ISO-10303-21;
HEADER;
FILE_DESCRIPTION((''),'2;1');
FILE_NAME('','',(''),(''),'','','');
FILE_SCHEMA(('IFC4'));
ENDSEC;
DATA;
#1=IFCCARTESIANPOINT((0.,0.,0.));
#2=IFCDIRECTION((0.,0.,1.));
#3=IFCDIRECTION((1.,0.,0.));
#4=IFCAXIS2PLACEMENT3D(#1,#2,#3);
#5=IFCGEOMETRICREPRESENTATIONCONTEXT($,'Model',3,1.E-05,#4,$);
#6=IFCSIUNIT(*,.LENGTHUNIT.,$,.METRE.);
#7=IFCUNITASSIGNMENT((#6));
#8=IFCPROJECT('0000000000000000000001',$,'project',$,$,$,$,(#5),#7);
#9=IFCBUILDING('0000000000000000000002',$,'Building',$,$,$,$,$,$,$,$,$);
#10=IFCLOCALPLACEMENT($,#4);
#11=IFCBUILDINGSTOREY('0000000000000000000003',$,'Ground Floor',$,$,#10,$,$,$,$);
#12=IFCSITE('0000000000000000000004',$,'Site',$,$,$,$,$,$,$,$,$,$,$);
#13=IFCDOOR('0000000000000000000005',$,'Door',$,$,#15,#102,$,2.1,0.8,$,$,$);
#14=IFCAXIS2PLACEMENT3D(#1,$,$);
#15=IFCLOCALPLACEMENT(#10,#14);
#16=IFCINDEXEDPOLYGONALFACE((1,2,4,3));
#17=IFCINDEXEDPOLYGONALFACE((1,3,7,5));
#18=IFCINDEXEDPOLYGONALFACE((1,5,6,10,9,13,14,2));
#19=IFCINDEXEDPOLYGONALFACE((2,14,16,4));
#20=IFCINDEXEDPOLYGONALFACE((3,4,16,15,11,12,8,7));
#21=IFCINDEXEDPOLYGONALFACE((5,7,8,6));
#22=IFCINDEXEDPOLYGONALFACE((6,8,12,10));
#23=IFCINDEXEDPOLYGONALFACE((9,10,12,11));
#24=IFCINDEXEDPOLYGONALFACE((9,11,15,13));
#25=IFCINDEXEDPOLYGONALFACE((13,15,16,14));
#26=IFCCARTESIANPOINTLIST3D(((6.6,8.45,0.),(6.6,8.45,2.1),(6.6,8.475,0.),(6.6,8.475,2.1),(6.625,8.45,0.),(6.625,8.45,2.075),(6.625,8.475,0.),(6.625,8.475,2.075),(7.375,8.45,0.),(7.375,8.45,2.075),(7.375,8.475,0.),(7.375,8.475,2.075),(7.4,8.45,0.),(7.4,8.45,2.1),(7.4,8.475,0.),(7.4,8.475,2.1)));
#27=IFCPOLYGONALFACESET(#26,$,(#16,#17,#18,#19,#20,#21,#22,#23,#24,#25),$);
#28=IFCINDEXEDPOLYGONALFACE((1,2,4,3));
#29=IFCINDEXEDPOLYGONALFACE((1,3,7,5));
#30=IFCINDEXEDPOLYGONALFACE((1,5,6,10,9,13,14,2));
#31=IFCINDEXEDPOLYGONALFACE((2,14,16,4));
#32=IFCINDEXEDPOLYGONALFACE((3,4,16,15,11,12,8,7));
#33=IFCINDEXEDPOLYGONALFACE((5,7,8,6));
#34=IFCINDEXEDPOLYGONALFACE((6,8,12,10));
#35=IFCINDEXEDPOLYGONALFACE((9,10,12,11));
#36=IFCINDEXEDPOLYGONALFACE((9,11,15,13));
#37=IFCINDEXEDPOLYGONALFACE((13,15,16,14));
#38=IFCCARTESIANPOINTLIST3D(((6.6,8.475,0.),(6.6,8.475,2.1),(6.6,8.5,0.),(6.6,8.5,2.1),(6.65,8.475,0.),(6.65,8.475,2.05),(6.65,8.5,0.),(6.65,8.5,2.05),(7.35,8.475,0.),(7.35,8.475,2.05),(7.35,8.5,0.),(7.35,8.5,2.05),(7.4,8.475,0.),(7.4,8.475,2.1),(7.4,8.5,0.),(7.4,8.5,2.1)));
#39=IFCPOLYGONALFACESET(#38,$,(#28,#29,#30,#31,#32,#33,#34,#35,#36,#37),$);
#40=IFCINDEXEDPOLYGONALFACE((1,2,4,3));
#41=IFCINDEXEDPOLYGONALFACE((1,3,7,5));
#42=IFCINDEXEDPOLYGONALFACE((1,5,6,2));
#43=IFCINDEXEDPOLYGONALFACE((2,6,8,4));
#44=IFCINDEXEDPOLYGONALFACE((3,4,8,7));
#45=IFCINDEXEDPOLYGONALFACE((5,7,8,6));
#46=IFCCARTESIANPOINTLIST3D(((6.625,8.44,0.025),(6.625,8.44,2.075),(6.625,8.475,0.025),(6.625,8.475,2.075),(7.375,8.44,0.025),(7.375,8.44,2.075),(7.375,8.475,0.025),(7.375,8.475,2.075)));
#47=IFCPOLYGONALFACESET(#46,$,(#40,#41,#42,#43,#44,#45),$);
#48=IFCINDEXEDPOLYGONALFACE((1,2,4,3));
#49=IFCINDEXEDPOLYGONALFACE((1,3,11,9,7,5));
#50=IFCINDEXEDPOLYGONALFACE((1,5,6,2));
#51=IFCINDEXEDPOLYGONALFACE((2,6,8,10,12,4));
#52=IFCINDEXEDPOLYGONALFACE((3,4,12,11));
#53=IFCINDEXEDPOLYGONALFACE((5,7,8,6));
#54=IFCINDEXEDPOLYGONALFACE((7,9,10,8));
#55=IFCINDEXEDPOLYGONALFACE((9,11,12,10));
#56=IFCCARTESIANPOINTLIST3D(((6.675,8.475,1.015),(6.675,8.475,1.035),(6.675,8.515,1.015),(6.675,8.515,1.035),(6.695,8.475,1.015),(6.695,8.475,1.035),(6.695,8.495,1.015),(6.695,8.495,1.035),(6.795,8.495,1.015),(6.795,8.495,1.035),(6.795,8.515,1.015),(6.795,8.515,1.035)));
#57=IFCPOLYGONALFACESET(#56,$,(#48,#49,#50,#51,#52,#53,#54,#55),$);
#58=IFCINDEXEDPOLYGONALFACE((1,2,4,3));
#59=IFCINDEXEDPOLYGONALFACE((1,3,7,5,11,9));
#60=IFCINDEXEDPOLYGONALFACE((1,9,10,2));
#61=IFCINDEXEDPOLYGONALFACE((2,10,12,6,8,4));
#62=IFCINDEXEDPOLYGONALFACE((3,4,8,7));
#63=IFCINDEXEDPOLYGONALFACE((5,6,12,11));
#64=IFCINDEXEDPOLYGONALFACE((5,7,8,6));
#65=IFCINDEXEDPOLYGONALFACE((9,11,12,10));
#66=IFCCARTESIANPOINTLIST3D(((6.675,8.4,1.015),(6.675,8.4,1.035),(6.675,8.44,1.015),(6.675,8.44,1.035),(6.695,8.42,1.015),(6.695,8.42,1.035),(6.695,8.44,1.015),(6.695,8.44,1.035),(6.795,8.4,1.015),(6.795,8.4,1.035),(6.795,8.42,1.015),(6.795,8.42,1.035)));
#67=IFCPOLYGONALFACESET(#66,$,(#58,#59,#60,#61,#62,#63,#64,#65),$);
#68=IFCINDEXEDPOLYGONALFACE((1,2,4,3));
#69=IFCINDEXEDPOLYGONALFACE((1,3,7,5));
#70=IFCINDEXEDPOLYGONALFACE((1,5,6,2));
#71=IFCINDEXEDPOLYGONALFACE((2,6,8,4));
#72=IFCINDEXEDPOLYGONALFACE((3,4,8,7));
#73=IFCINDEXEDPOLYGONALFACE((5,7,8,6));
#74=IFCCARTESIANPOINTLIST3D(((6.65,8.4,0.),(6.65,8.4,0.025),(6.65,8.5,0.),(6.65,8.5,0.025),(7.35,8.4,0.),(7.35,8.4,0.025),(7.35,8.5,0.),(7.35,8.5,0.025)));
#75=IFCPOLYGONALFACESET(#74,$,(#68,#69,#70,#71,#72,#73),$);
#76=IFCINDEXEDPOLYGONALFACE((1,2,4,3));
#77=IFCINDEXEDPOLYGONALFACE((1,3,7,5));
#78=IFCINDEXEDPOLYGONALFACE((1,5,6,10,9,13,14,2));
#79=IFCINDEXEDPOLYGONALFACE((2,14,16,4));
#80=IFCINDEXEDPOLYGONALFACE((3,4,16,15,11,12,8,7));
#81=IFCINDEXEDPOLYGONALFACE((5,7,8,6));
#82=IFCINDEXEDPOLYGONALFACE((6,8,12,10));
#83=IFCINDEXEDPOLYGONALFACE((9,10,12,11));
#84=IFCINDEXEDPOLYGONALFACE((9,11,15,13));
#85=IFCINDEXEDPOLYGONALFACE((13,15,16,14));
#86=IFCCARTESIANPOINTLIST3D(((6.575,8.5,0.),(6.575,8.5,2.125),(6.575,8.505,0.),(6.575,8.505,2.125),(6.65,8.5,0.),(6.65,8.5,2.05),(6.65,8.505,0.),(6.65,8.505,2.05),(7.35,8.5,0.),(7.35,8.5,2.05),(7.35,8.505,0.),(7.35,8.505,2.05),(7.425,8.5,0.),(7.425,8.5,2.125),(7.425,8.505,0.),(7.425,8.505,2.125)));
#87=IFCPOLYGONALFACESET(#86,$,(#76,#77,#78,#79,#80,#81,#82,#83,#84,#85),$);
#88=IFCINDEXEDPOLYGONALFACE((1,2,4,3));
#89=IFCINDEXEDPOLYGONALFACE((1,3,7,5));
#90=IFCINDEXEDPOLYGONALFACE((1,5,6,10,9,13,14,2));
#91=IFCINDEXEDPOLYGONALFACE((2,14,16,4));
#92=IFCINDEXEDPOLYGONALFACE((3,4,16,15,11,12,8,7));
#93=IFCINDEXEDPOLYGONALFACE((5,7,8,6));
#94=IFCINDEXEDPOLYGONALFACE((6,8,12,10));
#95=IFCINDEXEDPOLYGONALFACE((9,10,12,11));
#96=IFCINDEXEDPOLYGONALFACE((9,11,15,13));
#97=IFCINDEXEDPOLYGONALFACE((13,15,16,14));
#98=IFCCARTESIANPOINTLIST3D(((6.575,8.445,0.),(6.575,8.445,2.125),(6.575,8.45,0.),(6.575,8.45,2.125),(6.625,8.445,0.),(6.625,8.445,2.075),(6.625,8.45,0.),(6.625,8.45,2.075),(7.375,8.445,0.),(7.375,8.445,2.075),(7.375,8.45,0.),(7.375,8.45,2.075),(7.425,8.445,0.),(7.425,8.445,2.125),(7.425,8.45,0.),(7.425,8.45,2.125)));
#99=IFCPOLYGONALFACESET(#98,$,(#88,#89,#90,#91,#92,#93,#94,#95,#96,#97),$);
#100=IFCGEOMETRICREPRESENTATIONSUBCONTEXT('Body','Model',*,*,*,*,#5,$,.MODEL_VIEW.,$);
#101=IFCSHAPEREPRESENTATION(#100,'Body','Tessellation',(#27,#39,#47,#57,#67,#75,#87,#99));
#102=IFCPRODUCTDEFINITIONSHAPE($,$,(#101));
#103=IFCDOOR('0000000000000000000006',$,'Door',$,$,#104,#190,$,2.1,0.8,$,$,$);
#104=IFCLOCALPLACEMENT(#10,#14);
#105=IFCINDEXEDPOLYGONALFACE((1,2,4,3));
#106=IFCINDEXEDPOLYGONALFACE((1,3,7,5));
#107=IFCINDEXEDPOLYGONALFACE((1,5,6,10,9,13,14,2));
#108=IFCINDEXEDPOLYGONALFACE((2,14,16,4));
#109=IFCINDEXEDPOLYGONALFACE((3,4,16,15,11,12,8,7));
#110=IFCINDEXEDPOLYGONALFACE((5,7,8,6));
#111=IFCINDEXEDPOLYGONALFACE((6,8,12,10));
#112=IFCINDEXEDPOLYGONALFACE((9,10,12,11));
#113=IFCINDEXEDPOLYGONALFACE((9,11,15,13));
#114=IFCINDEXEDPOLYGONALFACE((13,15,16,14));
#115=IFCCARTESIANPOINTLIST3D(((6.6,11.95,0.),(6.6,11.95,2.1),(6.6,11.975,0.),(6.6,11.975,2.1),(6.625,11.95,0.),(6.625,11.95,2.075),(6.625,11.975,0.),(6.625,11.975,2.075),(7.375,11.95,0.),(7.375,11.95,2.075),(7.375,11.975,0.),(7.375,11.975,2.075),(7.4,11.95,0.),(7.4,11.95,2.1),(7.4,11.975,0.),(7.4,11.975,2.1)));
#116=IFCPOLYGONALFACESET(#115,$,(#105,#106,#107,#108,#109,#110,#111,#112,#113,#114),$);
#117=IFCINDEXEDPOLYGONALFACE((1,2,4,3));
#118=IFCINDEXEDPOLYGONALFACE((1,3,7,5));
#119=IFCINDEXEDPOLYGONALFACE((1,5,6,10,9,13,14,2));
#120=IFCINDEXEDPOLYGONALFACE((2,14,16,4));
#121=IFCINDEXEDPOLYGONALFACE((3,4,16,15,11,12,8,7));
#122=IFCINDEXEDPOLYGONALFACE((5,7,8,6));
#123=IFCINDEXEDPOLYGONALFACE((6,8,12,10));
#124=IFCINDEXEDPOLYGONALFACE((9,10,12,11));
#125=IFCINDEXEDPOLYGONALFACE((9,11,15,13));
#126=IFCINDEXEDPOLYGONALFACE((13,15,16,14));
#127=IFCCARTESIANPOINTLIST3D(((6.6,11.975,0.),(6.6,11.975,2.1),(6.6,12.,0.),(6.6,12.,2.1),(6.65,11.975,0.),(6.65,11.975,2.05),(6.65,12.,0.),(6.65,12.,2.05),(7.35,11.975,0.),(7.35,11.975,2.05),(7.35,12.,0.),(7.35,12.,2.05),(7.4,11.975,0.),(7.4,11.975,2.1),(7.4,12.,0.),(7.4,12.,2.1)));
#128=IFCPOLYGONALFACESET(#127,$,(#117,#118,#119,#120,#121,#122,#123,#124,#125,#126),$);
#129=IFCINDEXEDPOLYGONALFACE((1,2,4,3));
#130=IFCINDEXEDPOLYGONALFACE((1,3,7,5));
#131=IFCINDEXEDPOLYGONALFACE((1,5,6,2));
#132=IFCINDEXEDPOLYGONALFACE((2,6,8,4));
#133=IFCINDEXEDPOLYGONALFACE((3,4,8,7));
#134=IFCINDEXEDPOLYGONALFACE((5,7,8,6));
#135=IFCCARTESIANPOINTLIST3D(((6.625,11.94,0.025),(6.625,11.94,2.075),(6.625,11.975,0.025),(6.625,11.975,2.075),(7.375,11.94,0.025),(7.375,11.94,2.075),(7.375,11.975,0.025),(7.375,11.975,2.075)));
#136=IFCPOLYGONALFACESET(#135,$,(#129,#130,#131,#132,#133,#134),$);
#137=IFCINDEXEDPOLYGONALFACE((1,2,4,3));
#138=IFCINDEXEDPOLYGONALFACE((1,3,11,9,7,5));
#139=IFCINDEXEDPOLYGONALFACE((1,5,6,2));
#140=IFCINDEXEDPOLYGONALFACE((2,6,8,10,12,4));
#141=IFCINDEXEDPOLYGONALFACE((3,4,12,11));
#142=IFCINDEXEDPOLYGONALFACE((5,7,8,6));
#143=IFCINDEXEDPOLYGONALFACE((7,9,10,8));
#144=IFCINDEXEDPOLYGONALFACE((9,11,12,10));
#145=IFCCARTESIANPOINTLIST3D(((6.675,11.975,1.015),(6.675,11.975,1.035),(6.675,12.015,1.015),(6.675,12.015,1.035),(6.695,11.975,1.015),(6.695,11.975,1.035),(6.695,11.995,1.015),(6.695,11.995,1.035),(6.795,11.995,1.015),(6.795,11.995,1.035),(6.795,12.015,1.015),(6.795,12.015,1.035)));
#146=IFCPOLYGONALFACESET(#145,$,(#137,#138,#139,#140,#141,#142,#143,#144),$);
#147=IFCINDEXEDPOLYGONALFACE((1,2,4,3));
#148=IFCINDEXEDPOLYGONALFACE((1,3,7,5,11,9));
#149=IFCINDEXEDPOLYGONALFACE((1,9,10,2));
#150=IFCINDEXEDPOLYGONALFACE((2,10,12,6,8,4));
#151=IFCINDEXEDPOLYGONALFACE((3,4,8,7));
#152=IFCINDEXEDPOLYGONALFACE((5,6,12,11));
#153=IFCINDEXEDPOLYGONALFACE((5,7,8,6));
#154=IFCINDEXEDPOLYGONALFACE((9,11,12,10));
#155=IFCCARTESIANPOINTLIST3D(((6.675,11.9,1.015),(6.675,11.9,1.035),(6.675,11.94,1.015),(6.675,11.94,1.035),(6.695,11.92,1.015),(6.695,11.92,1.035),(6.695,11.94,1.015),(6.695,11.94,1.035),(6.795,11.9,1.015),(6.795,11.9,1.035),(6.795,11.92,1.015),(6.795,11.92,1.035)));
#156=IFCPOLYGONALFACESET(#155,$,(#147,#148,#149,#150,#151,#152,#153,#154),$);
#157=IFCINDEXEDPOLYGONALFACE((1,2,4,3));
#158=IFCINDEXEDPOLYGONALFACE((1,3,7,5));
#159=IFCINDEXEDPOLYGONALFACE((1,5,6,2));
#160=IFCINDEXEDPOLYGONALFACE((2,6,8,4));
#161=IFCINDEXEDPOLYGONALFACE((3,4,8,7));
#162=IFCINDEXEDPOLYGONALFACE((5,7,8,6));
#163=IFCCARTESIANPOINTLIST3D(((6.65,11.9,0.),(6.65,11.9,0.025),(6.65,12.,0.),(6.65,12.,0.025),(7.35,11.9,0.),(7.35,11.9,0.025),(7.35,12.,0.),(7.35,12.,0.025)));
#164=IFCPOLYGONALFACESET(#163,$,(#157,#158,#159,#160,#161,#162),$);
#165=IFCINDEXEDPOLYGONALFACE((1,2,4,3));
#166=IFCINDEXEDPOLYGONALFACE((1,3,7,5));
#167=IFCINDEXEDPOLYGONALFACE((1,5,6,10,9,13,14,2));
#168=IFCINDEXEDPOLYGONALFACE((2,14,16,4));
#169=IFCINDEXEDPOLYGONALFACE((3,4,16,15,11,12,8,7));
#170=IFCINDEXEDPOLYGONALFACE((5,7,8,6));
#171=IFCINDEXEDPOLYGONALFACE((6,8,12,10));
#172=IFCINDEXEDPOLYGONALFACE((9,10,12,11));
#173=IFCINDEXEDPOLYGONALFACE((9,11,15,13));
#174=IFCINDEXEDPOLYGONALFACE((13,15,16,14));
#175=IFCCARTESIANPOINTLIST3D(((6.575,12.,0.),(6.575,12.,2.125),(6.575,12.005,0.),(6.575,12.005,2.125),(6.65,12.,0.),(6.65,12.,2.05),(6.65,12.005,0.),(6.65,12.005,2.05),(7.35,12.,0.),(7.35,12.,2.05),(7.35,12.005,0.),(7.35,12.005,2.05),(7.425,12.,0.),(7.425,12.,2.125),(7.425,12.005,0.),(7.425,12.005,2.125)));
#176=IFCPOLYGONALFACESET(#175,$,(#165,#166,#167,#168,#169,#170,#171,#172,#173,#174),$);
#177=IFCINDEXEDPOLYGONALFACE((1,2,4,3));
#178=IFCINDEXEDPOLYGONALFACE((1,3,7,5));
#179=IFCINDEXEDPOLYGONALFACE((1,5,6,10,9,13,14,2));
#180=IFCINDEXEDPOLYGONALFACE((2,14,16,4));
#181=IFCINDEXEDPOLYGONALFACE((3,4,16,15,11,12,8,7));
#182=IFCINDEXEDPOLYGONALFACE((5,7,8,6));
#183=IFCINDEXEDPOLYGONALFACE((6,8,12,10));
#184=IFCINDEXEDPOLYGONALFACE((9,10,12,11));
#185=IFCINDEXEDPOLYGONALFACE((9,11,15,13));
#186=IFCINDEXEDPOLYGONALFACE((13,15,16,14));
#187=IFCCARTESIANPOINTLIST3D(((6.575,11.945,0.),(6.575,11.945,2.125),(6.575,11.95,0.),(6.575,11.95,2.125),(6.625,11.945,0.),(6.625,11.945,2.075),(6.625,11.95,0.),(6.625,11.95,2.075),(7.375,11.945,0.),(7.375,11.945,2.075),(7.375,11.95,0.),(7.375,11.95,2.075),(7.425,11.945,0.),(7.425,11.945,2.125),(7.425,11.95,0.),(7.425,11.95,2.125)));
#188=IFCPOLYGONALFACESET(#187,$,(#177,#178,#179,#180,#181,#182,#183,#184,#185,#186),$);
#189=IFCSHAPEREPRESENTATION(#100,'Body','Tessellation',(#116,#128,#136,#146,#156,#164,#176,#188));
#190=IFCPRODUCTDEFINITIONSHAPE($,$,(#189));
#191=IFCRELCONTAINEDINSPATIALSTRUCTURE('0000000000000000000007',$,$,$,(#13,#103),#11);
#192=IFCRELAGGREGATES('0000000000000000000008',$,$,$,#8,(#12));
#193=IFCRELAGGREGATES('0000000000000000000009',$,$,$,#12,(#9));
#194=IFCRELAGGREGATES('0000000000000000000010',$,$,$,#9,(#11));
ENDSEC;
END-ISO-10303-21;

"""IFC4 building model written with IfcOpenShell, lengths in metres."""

from ifc_helpers import new_model, si_unit, frame, origin_with_axes, place, context, subcontext, project, spatial, line, indexed_curve, outline, extrude, element, save


model = new_model("IFC4")

# Units and contexts
model_context = context("Model", 3, precision=1e-05, world=origin_with_axes())
body_context = subcontext(model_context, "Body", "Model", "MODEL_VIEW")
ifc_project = project(units=[si_unit("LENGTHUNIT", "METRE")], contexts=[model_context])

# Site, building, storey
site = spatial("IfcSite", under=ifc_project, Name="Site")
building = spatial("IfcBuilding", under=site, Name="Building")
storey_placement = place(None, origin_with_axes())
storey = spatial("IfcBuildingStorey", under=building, at=storey_placement, Name="Ground Floor")

# Doors
door_1_placement = place(storey_placement, frame((7.4, 8.5, 0.0), z_axis=(0.0, 0.0, 1.0), x_axis=(-1.0, 0.0, 0.0)))
element("IfcDoor", 1, at=door_1_placement, inside=storey, Name="Door", OverallHeight=2.1, OverallWidth=0.8, context=body_context, shape_type="SweptSolid", body=[
    extrude(outline(indexed_curve([(0.0, 0.0), (0.0, 2.1), (0.8, 2.1), (0.8, 0.0), (0.775, 0.0), (0.775, 2.075), (0.025, 2.075), (0.025, 0.0)], segments=[line(1, 2, 3, 4, 5, 6, 7, 8, 1)])), frame((0.0, 0.025, 0.0), z_axis=(0.0, -1.0, 0.0), x_axis=(1.0, 0.0, 0.0)), (0.0, 0.0, -1.0), 0.025),
    extrude(outline(indexed_curve([(0.0, 0.0), (0.0, 2.1), (0.8, 2.1), (0.8, 0.0), (0.75, 0.0), (0.75, 2.05), (0.05, 2.05), (0.05, 0.0)], segments=[line(1, 2, 3, 4, 5, 6, 7, 8, 1)])), frame((0.0, 0.0, 0.0), z_axis=(0.0, -1.0, 0.0), x_axis=(1.0, 0.0, 0.0)), (0.0, 0.0, -1.0), 0.025),
    extrude(outline(indexed_curve([(0.0, 0.0), (0.75, 0.0), (0.75, 0.035), (0.0, 0.035)], segments=[line(1, 2, 3, 4, 1)])), frame((0.025, 0.025, 0.025), z_axis=(0.0, 0.0, 1.0), x_axis=(1.0, 0.0, 0.0)), (0.0, 0.0, 1.0), 2.05),
    extrude(outline(indexed_curve([(0.0, 0.0), (0.0, -0.04), (-0.12, -0.04), (-0.12, -0.02), (-0.02, -0.02), (-0.02, 0.0)], segments=[line(1, 2, 3, 4, 5, 6, 1)])), frame((0.725, 0.025, 1.015), z_axis=(0.0, 0.0, 1.0), x_axis=(1.0, 0.0, 0.0)), (0.0, 0.0, 1.0), 0.02),
    extrude(outline(indexed_curve([(0.0, 0.0), (0.0, 0.04), (-0.12, 0.04), (-0.12, 0.02), (-0.02, 0.02), (-0.02, 0.0)], segments=[line(1, 2, 3, 4, 5, 6, 1)])), frame((0.725, 0.06, 1.015), z_axis=(0.0, 0.0, 1.0), x_axis=(1.0, 0.0, 0.0)), (0.0, 0.0, 1.0), 0.02),
    extrude(outline(indexed_curve([(0.0, 0.0), (0.7, 0.0), (0.7, 0.1), (0.0, 0.1)], segments=[line(1, 2, 3, 4, 1)])), frame((0.05, 0.0, 0.0), z_axis=(0.0, 0.0, 1.0), x_axis=(1.0, 0.0, 0.0)), (0.0, 0.0, 1.0), 0.025),
    extrude(outline(indexed_curve([(0.0, 0.0), (0.0, 2.125), (0.85, 2.125), (0.85, 0.0), (0.775, 0.0), (0.775, 2.05), (0.075, 2.05), (0.075, 0.0)], segments=[line(1, 2, 3, 4, 5, 6, 7, 8, 1)])), frame((-0.025, -0.005, 0.0), z_axis=(0.0, -1.0, 0.0), x_axis=(1.0, 0.0, 0.0)), (0.0, 0.0, -1.0), 0.005),
    extrude(outline(indexed_curve([(0.0, 0.0), (0.0, 2.125), (0.85, 2.125), (0.85, 0.0), (0.8, 0.0), (0.8, 2.075), (0.05, 2.075), (0.05, 0.0)], segments=[line(1, 2, 3, 4, 5, 6, 7, 8, 1)])), frame((-0.025, 0.05, 0.0), z_axis=(0.0, -1.0, 0.0), x_axis=(1.0, 0.0, 0.0)), (0.0, 0.0, -1.0), 0.005),
])
door_2_placement = place(storey_placement, frame((7.4, 12.0, 0.0), z_axis=(0.0, 0.0, 1.0), x_axis=(-1.0, 0.0, 0.0)))
element("IfcDoor", 2, at=door_2_placement, inside=storey, Name="Door", OverallHeight=2.1, OverallWidth=0.8, context=body_context, shape_type="SweptSolid", body=[
    extrude(outline(indexed_curve([(0.0, 0.0), (0.0, 2.1), (0.8, 2.1), (0.8, 0.0), (0.775, 0.0), (0.775, 2.075), (0.025, 2.075), (0.025, 0.0)], segments=[line(1, 2, 3, 4, 5, 6, 7, 8, 1)])), frame((0.0, 0.025, 0.0), z_axis=(0.0, -1.0, 0.0), x_axis=(1.0, 0.0, 0.0)), (0.0, 0.0, -1.0), 0.025),
    extrude(outline(indexed_curve([(0.0, 0.0), (0.0, 2.1), (0.8, 2.1), (0.8, 0.0), (0.75, 0.0), (0.75, 2.05), (0.05, 2.05), (0.05, 0.0)], segments=[line(1, 2, 3, 4, 5, 6, 7, 8, 1)])), frame((0.0, 0.0, 0.0), z_axis=(0.0, -1.0, 0.0), x_axis=(1.0, 0.0, 0.0)), (0.0, 0.0, -1.0), 0.025),
    extrude(outline(indexed_curve([(0.0, 0.0), (0.75, 0.0), (0.75, 0.035), (0.0, 0.035)], segments=[line(1, 2, 3, 4, 1)])), frame((0.025, 0.025, 0.025), z_axis=(0.0, 0.0, 1.0), x_axis=(1.0, 0.0, 0.0)), (0.0, 0.0, 1.0), 2.05),
    extrude(outline(indexed_curve([(0.0, 0.0), (0.0, -0.04), (-0.12, -0.04), (-0.12, -0.02), (-0.02, -0.02), (-0.02, 0.0)], segments=[line(1, 2, 3, 4, 5, 6, 1)])), frame((0.725, 0.025, 1.015), z_axis=(0.0, 0.0, 1.0), x_axis=(1.0, 0.0, 0.0)), (0.0, 0.0, 1.0), 0.02),
    extrude(outline(indexed_curve([(0.0, 0.0), (0.0, 0.04), (-0.12, 0.04), (-0.12, 0.02), (-0.02, 0.02), (-0.02, 0.0)], segments=[line(1, 2, 3, 4, 5, 6, 1)])), frame((0.725, 0.06, 1.015), z_axis=(0.0, 0.0, 1.0), x_axis=(1.0, 0.0, 0.0)), (0.0, 0.0, 1.0), 0.02),
    extrude(outline(indexed_curve([(0.0, 0.0), (0.7, 0.0), (0.7, 0.1), (0.0, 0.1)], segments=[line(1, 2, 3, 4, 1)])), frame((0.05, 0.0, 0.0), z_axis=(0.0, 0.0, 1.0), x_axis=(1.0, 0.0, 0.0)), (0.0, 0.0, 1.0), 0.025),
    extrude(outline(indexed_curve([(0.0, 0.0), (0.0, 2.125), (0.85, 2.125), (0.85, 0.0), (0.775, 0.0), (0.775, 2.05), (0.075, 2.05), (0.075, 0.0)], segments=[line(1, 2, 3, 4, 5, 6, 7, 8, 1)])), frame((-0.025, -0.005, 0.0), z_axis=(0.0, -1.0, 0.0), x_axis=(1.0, 0.0, 0.0)), (0.0, 0.0, -1.0), 0.005),
    extrude(outline(indexed_curve([(0.0, 0.0), (0.0, 2.125), (0.85, 2.125), (0.85, 0.0), (0.8, 0.0), (0.8, 2.075), (0.05, 2.075), (0.05, 0.0)], segments=[line(1, 2, 3, 4, 5, 6, 7, 8, 1)])), frame((-0.025, 0.05, 0.0), z_axis=(0.0, -1.0, 0.0), x_axis=(1.0, 0.0, 0.0)), (0.0, 0.0, -1.0), 0.005),
])

save(model, "model.ifc")
